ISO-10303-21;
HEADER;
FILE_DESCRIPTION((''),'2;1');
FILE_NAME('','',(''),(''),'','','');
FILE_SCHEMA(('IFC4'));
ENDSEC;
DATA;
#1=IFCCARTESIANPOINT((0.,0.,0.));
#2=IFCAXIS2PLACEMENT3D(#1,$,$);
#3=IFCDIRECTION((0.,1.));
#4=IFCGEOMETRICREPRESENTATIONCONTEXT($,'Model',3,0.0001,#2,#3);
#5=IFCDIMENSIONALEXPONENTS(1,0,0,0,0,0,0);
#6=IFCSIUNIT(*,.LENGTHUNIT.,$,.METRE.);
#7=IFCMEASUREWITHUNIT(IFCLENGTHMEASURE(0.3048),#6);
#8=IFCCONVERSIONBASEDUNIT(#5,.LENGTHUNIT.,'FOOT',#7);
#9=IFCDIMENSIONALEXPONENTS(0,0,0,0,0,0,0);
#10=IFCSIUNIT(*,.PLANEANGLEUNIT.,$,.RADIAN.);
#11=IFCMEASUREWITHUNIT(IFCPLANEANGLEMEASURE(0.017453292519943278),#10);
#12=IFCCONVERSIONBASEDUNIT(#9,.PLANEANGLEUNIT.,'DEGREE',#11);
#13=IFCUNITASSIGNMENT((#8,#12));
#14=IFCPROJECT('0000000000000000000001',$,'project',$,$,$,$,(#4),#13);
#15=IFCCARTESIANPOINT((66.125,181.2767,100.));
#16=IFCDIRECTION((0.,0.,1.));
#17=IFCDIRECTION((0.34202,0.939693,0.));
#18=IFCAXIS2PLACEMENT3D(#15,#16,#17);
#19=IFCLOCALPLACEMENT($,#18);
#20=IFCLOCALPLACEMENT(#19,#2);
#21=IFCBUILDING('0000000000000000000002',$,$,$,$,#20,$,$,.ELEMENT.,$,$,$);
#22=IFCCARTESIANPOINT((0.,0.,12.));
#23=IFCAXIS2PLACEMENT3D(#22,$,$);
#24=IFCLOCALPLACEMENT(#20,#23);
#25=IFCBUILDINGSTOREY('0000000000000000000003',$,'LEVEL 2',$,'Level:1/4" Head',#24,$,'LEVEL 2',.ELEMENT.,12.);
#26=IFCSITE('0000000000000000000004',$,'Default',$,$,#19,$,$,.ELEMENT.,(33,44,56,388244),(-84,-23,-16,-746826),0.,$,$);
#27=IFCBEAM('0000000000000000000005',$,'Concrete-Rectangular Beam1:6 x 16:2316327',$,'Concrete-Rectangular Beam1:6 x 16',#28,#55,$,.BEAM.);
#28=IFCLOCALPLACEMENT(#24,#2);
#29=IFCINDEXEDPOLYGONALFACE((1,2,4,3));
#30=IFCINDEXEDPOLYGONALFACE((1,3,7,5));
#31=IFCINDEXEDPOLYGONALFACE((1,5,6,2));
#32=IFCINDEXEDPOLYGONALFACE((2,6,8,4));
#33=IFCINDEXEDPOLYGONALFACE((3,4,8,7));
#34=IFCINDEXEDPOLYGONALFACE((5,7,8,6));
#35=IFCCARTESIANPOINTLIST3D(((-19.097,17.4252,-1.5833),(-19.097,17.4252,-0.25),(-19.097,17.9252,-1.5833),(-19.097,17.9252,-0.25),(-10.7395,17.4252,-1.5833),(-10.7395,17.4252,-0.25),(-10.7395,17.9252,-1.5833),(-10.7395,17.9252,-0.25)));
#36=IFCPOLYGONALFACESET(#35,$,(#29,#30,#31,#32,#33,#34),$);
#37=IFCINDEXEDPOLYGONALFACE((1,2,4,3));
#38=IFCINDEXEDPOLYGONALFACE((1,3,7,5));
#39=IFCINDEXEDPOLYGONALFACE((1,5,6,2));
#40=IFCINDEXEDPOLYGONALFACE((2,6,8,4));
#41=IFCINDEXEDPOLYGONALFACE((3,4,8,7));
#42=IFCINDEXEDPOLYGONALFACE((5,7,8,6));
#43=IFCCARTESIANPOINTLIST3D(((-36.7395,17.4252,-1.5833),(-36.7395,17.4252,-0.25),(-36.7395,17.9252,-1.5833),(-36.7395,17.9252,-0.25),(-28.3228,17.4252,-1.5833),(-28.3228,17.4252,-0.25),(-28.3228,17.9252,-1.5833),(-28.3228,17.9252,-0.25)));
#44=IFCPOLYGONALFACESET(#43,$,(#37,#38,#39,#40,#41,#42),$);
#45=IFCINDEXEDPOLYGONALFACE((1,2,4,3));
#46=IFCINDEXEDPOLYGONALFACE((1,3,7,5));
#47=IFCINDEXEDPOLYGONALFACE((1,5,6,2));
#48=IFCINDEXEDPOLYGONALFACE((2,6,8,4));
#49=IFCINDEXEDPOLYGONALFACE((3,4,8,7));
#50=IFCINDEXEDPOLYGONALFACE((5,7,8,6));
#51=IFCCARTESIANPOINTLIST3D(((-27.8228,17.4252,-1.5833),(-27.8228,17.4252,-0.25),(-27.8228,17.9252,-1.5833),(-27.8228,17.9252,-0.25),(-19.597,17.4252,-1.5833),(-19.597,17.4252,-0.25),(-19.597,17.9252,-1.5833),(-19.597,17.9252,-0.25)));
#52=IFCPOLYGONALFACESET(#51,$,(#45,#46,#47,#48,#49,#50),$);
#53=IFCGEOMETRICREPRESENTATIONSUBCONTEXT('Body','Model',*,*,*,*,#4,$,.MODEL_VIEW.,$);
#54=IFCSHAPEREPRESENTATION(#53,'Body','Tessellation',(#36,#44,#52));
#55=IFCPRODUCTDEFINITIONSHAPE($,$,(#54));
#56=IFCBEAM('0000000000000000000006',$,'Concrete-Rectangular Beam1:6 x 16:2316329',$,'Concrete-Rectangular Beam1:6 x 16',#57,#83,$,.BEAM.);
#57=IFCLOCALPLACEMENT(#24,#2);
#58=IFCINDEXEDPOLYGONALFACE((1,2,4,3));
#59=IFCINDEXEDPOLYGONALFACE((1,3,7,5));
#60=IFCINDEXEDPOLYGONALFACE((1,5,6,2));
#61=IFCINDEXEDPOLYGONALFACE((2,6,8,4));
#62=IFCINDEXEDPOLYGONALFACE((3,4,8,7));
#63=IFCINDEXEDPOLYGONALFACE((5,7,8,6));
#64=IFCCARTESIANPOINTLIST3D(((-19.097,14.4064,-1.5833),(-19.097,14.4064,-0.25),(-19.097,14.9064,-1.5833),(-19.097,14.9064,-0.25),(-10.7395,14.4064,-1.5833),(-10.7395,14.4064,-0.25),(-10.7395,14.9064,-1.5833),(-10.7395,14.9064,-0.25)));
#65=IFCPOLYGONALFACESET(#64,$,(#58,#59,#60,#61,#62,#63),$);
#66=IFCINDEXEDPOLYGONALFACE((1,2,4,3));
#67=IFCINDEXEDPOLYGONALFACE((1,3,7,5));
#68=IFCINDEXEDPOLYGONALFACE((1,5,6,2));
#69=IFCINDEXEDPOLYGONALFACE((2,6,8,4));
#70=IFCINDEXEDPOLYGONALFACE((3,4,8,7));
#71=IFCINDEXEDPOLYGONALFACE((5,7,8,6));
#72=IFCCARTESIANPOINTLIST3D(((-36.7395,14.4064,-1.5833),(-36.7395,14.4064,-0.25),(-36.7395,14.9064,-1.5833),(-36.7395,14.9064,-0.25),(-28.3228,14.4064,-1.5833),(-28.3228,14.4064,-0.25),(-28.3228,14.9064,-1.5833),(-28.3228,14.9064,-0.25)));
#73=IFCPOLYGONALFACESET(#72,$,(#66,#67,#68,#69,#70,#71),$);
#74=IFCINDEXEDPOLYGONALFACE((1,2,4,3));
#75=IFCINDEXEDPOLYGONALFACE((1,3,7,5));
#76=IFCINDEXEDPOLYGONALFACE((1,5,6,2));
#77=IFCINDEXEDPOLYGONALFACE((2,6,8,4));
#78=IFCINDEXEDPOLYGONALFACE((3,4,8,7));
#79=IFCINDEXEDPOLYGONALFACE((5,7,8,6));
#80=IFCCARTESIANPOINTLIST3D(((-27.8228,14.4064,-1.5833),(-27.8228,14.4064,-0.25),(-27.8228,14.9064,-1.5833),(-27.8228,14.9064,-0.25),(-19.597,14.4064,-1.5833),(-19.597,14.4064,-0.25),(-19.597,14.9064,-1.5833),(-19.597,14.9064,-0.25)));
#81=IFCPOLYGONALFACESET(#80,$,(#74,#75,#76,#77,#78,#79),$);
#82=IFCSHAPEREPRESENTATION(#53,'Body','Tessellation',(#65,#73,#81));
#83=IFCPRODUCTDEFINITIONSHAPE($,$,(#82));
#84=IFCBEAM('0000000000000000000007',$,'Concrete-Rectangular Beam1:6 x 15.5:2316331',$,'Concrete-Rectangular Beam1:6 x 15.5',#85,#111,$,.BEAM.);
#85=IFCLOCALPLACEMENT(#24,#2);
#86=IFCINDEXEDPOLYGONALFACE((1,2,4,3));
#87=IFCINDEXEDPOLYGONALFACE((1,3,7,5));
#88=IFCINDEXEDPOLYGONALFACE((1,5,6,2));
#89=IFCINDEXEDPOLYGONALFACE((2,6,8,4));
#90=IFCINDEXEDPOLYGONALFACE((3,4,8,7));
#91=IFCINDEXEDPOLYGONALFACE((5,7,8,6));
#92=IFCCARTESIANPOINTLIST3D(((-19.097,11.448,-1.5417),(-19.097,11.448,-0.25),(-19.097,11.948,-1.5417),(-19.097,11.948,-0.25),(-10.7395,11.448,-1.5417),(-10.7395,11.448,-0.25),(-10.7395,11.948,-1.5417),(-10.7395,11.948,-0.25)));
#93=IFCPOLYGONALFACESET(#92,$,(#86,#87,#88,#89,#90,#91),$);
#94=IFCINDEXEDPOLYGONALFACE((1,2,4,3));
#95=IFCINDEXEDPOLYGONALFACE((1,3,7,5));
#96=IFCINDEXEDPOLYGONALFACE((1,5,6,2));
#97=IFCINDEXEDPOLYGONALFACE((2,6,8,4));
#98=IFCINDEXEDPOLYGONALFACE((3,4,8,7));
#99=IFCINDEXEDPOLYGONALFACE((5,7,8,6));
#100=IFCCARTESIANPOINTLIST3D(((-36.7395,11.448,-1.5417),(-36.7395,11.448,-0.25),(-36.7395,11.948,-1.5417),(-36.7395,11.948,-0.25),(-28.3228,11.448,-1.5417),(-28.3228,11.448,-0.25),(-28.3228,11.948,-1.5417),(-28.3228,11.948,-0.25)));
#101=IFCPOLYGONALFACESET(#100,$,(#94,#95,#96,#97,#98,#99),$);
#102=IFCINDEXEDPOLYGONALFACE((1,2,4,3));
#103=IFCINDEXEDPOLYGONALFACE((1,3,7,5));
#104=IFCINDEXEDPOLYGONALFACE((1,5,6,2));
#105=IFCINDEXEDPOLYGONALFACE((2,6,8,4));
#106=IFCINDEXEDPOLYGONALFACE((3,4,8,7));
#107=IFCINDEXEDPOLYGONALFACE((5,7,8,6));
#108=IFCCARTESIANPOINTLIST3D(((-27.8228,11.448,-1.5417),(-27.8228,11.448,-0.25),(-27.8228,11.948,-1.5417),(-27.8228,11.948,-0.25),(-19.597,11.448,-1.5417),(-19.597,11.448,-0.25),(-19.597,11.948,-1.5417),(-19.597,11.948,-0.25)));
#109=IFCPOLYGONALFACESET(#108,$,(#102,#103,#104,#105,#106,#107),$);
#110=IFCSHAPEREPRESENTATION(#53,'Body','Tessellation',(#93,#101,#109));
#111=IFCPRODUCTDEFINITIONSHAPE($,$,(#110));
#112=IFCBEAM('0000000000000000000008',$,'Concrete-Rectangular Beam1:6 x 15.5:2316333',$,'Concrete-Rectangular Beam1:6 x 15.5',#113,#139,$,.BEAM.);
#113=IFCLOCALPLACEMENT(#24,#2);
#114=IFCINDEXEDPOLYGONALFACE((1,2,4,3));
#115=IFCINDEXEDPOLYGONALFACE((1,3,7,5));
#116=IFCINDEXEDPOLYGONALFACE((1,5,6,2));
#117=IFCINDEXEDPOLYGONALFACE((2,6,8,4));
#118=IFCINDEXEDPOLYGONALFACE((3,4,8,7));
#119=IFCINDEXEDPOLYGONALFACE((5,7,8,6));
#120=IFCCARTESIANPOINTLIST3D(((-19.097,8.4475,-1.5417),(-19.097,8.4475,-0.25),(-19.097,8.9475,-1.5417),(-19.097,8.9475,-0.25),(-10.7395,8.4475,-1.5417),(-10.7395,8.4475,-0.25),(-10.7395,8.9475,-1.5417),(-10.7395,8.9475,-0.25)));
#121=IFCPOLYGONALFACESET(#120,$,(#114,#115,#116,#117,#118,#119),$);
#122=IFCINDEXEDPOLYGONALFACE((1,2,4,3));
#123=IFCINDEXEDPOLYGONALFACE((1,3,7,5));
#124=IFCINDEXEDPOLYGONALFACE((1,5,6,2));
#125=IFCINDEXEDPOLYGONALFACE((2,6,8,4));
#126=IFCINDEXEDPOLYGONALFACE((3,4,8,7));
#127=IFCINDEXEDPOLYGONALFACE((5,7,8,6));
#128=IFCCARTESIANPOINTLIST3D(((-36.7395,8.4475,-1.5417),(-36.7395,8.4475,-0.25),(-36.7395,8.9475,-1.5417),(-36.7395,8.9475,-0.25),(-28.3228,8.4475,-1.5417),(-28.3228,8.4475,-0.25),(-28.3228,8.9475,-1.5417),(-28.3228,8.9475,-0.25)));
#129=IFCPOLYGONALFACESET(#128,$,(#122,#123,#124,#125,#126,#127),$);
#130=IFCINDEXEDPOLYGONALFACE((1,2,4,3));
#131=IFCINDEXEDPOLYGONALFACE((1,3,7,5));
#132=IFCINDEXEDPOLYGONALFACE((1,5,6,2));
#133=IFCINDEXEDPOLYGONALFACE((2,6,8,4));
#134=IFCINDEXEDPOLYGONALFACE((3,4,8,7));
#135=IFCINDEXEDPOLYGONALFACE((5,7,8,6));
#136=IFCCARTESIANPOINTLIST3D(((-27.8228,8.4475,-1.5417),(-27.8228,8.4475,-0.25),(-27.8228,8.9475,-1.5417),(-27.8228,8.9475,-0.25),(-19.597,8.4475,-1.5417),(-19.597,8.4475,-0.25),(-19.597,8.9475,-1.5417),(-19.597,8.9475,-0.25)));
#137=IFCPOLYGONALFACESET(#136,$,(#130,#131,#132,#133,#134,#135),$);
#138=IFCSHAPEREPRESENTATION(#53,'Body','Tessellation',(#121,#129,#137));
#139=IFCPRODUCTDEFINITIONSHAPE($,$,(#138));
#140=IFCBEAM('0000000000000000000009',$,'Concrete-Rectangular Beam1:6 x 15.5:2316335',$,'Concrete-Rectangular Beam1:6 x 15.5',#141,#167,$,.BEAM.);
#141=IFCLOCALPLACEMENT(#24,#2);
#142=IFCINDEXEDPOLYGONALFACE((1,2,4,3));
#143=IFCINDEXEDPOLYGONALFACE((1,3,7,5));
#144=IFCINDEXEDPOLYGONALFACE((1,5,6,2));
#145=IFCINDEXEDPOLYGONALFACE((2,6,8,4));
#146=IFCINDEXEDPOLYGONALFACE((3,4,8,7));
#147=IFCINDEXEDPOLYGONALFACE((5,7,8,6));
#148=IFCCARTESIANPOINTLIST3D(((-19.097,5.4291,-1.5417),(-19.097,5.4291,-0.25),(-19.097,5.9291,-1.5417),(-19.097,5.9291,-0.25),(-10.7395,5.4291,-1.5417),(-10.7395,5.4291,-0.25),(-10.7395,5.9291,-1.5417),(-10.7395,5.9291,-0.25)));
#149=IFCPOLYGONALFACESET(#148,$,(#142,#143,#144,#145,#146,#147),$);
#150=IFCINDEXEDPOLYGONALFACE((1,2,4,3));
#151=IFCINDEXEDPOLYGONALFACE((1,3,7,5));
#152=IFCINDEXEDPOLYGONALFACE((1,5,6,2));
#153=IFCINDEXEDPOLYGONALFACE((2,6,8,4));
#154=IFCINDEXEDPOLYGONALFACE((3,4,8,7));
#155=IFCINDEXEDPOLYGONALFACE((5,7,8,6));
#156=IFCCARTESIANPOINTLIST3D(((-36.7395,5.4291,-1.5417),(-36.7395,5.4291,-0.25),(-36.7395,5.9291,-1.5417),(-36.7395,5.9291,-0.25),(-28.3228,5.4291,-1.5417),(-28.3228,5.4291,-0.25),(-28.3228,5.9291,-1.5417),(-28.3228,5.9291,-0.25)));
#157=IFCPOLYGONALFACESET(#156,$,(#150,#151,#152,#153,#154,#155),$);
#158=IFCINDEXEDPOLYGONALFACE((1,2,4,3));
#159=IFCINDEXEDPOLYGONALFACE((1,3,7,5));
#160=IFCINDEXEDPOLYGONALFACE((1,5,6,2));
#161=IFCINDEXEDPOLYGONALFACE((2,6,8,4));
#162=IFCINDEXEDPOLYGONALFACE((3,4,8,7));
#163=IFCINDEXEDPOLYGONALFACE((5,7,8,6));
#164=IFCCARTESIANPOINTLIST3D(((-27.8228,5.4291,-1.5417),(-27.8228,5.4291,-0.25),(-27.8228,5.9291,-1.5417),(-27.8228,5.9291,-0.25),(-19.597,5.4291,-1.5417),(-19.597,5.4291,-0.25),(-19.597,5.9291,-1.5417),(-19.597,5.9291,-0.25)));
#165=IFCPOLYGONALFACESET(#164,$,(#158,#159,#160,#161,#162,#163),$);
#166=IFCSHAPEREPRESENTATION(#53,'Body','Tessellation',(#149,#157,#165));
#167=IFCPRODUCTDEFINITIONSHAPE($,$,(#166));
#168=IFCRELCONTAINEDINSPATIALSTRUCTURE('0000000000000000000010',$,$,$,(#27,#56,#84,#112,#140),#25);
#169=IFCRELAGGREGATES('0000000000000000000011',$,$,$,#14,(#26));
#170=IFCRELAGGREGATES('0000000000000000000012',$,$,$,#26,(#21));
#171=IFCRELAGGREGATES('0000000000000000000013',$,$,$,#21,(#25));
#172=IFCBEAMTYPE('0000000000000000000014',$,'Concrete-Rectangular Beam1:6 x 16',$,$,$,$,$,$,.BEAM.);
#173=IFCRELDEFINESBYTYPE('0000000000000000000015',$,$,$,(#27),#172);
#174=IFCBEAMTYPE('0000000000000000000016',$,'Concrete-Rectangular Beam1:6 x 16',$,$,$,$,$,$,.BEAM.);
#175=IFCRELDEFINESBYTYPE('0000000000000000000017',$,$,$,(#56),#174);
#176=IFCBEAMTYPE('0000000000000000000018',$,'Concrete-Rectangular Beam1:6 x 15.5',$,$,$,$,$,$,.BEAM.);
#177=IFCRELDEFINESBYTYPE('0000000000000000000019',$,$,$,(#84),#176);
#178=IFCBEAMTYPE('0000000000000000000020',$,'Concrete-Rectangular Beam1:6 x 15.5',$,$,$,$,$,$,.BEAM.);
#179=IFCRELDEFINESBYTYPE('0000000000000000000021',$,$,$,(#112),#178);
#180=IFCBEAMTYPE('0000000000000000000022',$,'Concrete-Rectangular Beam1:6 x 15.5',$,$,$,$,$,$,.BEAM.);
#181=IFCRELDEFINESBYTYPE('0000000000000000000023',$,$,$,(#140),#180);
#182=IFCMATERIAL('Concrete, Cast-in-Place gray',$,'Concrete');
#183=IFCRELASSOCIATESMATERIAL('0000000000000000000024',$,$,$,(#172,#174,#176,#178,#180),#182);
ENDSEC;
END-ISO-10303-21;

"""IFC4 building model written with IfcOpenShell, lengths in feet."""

from ifc_helpers import new_model, entity, si_unit, converted_unit, direction, frame, frame_2d, origin, place, context, subcontext, project, spatial, polyline, segment, composite_curve, rectangle, outline, extrude, source, transform, mapped, material, material_profile, profile_set, type_object, type_shapes, element, save


model = new_model("IFC4")

# Units and contexts
model_context = context("Model", 3, precision=0.0001, world=origin(), true_north=direction((0.0, 1.0)))
body_context = subcontext(model_context, "Body", "Model", "MODEL_VIEW")
ifc_project = project(units=[converted_unit("LENGTHUNIT", "FOOT", entity("IfcLengthMeasure", 0.3048), si_unit("LENGTHUNIT", "METRE"), dimensions=[1, 0, 0, 0, 0, 0, 0]), converted_unit("PLANEANGLEUNIT", "DEGREE", entity("IfcPlaneAngleMeasure", 0.017453292519943278), si_unit("PLANEANGLEUNIT", "RADIAN"), dimensions=[0, 0, 0, 0, 0, 0, 0])], contexts=[model_context])

# Site, building, storey
site_placement = place(None, frame((66.125, 181.2767, 100.0), z_axis=(0.0, 0.0, 1.0), x_axis=(0.34202, 0.939693, 0.0)))
site = spatial("IfcSite", under=ifc_project, at=site_placement, Name="Default", CompositionType="ELEMENT", RefLatitude=(33, 44, 56, 388244), RefLongitude=(-84, -23, -16, -746826), RefElevation=0.0)
building_placement = place(site_placement, origin())
building = spatial("IfcBuilding", under=site, at=building_placement, CompositionType="ELEMENT")
storey_placement = place(building_placement, frame((0.0, 0.0, 12.0)))
storey = spatial("IfcBuildingStorey", under=building, at=storey_placement, Name="LEVEL 2", ObjectType="Level:1/4\" Head", LongName="LEVEL 2", CompositionType="ELEMENT", Elevation=12.0)

# Beams
ifc_material = material(Name="Concrete, Cast-in-Place gray", Category="Concrete")
ifc_material_profile_1 = material_profile(ifc_material, rectangle(XDim=1.3333, YDim=0.5, at=frame_2d((0.0, 0.0), x_axis=(1.0, 0.0))), Name="6 x 16")
ifc_profile_set_1 = profile_set([ifc_material_profile_1], Name="6 x 16")
beam_type_1 = type_object("IfcBeamType", Name="Concrete-Rectangular Beam1:6 x 16", PredefinedType="BEAM", material=ifc_profile_set_1)
shared_shape_1 = source(origin(), body_context, "Body", "SweptSolid", [
    extrude(rectangle(XDim=1.3333, YDim=0.5, at=frame_2d((0.0, 0.0), x_axis=(1.0, 0.0))), frame((-19.097, 17.6752, 11.0833), z_axis=(1.0, 0.0, 0.0), x_axis=(0.0, 0.0, -1.0)), (0.0, 0.0, 1.0), 8.3575),
    extrude(rectangle(XDim=1.3333, YDim=0.5, at=frame_2d((0.0, 0.0), x_axis=(1.0, 0.0))), frame((-36.7395, 17.6752, 11.0833), z_axis=(1.0, 0.0, 0.0), x_axis=(0.0, 0.0, -1.0)), (0.0, 0.0, 1.0), 8.4167),
    extrude(rectangle(XDim=1.3333, YDim=0.5, at=frame_2d((0.0, 0.0), x_axis=(1.0, 0.0))), frame((-27.8228, 17.6752, 11.0833), z_axis=(1.0, 0.0, 0.0), x_axis=(0.0, 0.0, -1.0)), (0.0, 0.0, 1.0), 8.2258),
])
type_shapes(beam_type_1, [shared_shape_1])
beam_1_placement = place(storey_placement, frame((0.0, 0.0, -12.0)))
element("IfcBeam", 1, at=beam_1_placement, inside=storey, type_object=beam_type_1, Name="Concrete-Rectangular Beam1:6 x 16:2316327", ObjectType="Concrete-Rectangular Beam1:6 x 16", PredefinedType="BEAM", context=body_context, shape_type="MappedRepresentation", body=[
    mapped(shared_shape_1, transform((0.0, 0.0, 0.0), scale=1.0)),
])
beam_type_2 = type_object("IfcBeamType", Name="Concrete-Rectangular Beam1:6 x 16", PredefinedType="BEAM", material=ifc_profile_set_1)
shared_shape_2 = source(origin(), body_context, "Body", "SweptSolid", [
    extrude(rectangle(XDim=1.3333, YDim=0.5, at=frame_2d((0.0, 0.0), x_axis=(1.0, 0.0))), frame((-19.097, 14.6564, 11.0833), z_axis=(1.0, 0.0, 0.0), x_axis=(0.0, 0.0, -1.0)), (0.0, 0.0, 1.0), 8.3575),
    extrude(rectangle(XDim=1.3333, YDim=0.5, at=frame_2d((0.0, 0.0), x_axis=(1.0, 0.0))), frame((-36.7395, 14.6564, 11.0833), z_axis=(1.0, 0.0, 0.0), x_axis=(0.0, 0.0, -1.0)), (0.0, 0.0, 1.0), 8.4167),
    extrude(rectangle(XDim=1.3333, YDim=0.5, at=frame_2d((0.0, 0.0), x_axis=(1.0, 0.0))), frame((-27.8228, 14.6564, 11.0833), z_axis=(1.0, 0.0, 0.0), x_axis=(0.0, 0.0, -1.0)), (0.0, 0.0, 1.0), 8.2258),
])
type_shapes(beam_type_2, [shared_shape_2])
beam_2_placement = place(storey_placement, frame((0.0, 0.0, -12.0)))
element("IfcBeam", 2, at=beam_2_placement, inside=storey, type_object=beam_type_2, Name="Concrete-Rectangular Beam1:6 x 16:2316329", ObjectType="Concrete-Rectangular Beam1:6 x 16", PredefinedType="BEAM", context=body_context, shape_type="MappedRepresentation", body=[
    mapped(shared_shape_2, transform((0.0, 0.0, 0.0), scale=1.0)),
])
ifc_material_profile_2 = material_profile(ifc_material, outline(composite_curve([segment(polyline([(-0.25, 0.6458, 0.0), (0.25, 0.6458, 0.0)]), True, "CONTINUOUS"), segment(polyline([(0.25, 0.6458, 0.0), (0.25, -0.6458, 0.0)]), True, "CONTINUOUS"), segment(polyline([(0.25, -0.6458, 0.0), (-0.25, -0.6458, 0.0)]), True, "CONTINUOUS"), segment(polyline([(-0.25, -0.6458, 0.0), (-0.25, 0.6458, 0.0)]), True, "CONTINUOUS")], self_intersect=False), kind="CURVE"), Name="6 x 15.5")
ifc_material_profile_3 = material_profile(ifc_material, outline(composite_curve([segment(polyline([(-12.5417, 0.25, 0.6458), (-12.5417, 0.25, -0.6458)]), True, "CONTINUOUS"), segment(polyline([(-12.5417, 0.25, -0.6458), (-12.5417, -0.25, -0.6458)]), True, "CONTINUOUS"), segment(polyline([(-12.5417, -0.25, -0.6458), (-12.5417, -0.25, 0.6458)]), True, "CONTINUOUS"), segment(polyline([(-12.5417, -0.25, 0.6458), (-12.5417, 0.25, 0.6458)]), True, "CONTINUOUS")], self_intersect=False), kind="CURVE"), Name="6 x 15.5")
ifc_profile_set_2 = profile_set([ifc_material_profile_2, ifc_material_profile_3], Name="6 x 15.5")
beam_type_3 = type_object("IfcBeamType", Name="Concrete-Rectangular Beam1:6 x 15.5", PredefinedType="BEAM", material=ifc_profile_set_2)
shared_shape_3 = source(origin(), body_context, "Body", "SweptSolid", [
    extrude(rectangle(XDim=1.2917, YDim=0.5, at=frame_2d((0.0, 0.0), x_axis=(1.0, 0.0))), frame((-19.097, 11.698, 11.1042), z_axis=(1.0, 0.0, 0.0), x_axis=(0.0, 0.0, -1.0)), (0.0, 0.0, 1.0), 8.3575),
    extrude(rectangle(XDim=1.2917, YDim=0.5, at=frame_2d((0.0, 0.0), x_axis=(1.0, 0.0))), frame((-36.7395, 11.698, 11.1042), z_axis=(1.0, 0.0, 0.0), x_axis=(0.0, 0.0, -1.0)), (0.0, 0.0, 1.0), 8.4167),
    extrude(rectangle(XDim=1.2917, YDim=0.5, at=frame_2d((0.0, 0.0), x_axis=(1.0, 0.0))), frame((-27.8228, 11.698, 11.1042), z_axis=(1.0, 0.0, 0.0), x_axis=(0.0, 0.0, -1.0)), (0.0, 0.0, 1.0), 8.2258),
])
type_shapes(beam_type_3, [shared_shape_3])
beam_3_placement = place(storey_placement, frame((0.0, 0.0, -12.0)))
element("IfcBeam", 3, at=beam_3_placement, inside=storey, type_object=beam_type_3, Name="Concrete-Rectangular Beam1:6 x 15.5:2316331", ObjectType="Concrete-Rectangular Beam1:6 x 15.5", PredefinedType="BEAM", context=body_context, shape_type="MappedRepresentation", body=[
    mapped(shared_shape_3, transform((0.0, 0.0, 0.0), scale=1.0)),
])
beam_type_4 = type_object("IfcBeamType", Name="Concrete-Rectangular Beam1:6 x 15.5", PredefinedType="BEAM", material=ifc_profile_set_2)
shared_shape_4 = source(origin(), body_context, "Body", "SweptSolid", [
    extrude(rectangle(XDim=1.2917, YDim=0.5, at=frame_2d((0.0, 0.0), x_axis=(1.0, 0.0))), frame((-19.097, 8.6975, 11.1042), z_axis=(1.0, 0.0, 0.0), x_axis=(0.0, 0.0, -1.0)), (0.0, 0.0, 1.0), 8.3575),
    extrude(rectangle(XDim=1.2917, YDim=0.5, at=frame_2d((0.0, 0.0), x_axis=(1.0, 0.0))), frame((-36.7395, 8.6975, 11.1042), z_axis=(1.0, 0.0, 0.0), x_axis=(0.0, 0.0, -1.0)), (0.0, 0.0, 1.0), 8.4167),
    extrude(rectangle(XDim=1.2917, YDim=0.5, at=frame_2d((0.0, 0.0), x_axis=(1.0, 0.0))), frame((-27.8228, 8.6975, 11.1042), z_axis=(1.0, 0.0, 0.0), x_axis=(0.0, 0.0, -1.0)), (0.0, 0.0, 1.0), 8.2258),
])
type_shapes(beam_type_4, [shared_shape_4])
beam_4_placement = place(storey_placement, frame((0.0, 0.0, -12.0)))
element("IfcBeam", 4, at=beam_4_placement, inside=storey, type_object=beam_type_4, Name="Concrete-Rectangular Beam1:6 x 15.5:2316333", ObjectType="Concrete-Rectangular Beam1:6 x 15.5", PredefinedType="BEAM", context=body_context, shape_type="MappedRepresentation", body=[
    mapped(shared_shape_4, transform((0.0, 0.0, 0.0), scale=1.0)),
])
beam_type_5 = type_object("IfcBeamType", Name="Concrete-Rectangular Beam1:6 x 15.5", PredefinedType="BEAM", material=ifc_profile_set_2)
shared_shape_5 = source(origin(), body_context, "Body", "SweptSolid", [
    extrude(rectangle(XDim=1.2917, YDim=0.5, at=frame_2d((0.0, 0.0), x_axis=(1.0, 0.0))), frame((-19.097, 5.6791, 11.1042), z_axis=(1.0, 0.0, 0.0), x_axis=(0.0, 0.0, -1.0)), (0.0, 0.0, 1.0), 8.3575),
    extrude(rectangle(XDim=1.2917, YDim=0.5, at=frame_2d((0.0, 0.0), x_axis=(1.0, 0.0))), frame((-36.7395, 5.6791, 11.1042), z_axis=(1.0, 0.0, 0.0), x_axis=(0.0, 0.0, -1.0)), (0.0, 0.0, 1.0), 8.4167),
    extrude(rectangle(XDim=1.2917, YDim=0.5, at=frame_2d((0.0, 0.0), x_axis=(1.0, 0.0))), frame((-27.8228, 5.6791, 11.1042), z_axis=(1.0, 0.0, 0.0), x_axis=(0.0, 0.0, -1.0)), (0.0, 0.0, 1.0), 8.2258),
])
type_shapes(beam_type_5, [shared_shape_5])
beam_5_placement = place(storey_placement, frame((0.0, 0.0, -12.0)))
element("IfcBeam", 5, at=beam_5_placement, inside=storey, type_object=beam_type_5, Name="Concrete-Rectangular Beam1:6 x 15.5:2316335", ObjectType="Concrete-Rectangular Beam1:6 x 15.5", PredefinedType="BEAM", context=body_context, shape_type="MappedRepresentation", body=[
    mapped(shared_shape_5, transform((0.0, 0.0, 0.0), scale=1.0)),
])

save(model, "model.ifc")
